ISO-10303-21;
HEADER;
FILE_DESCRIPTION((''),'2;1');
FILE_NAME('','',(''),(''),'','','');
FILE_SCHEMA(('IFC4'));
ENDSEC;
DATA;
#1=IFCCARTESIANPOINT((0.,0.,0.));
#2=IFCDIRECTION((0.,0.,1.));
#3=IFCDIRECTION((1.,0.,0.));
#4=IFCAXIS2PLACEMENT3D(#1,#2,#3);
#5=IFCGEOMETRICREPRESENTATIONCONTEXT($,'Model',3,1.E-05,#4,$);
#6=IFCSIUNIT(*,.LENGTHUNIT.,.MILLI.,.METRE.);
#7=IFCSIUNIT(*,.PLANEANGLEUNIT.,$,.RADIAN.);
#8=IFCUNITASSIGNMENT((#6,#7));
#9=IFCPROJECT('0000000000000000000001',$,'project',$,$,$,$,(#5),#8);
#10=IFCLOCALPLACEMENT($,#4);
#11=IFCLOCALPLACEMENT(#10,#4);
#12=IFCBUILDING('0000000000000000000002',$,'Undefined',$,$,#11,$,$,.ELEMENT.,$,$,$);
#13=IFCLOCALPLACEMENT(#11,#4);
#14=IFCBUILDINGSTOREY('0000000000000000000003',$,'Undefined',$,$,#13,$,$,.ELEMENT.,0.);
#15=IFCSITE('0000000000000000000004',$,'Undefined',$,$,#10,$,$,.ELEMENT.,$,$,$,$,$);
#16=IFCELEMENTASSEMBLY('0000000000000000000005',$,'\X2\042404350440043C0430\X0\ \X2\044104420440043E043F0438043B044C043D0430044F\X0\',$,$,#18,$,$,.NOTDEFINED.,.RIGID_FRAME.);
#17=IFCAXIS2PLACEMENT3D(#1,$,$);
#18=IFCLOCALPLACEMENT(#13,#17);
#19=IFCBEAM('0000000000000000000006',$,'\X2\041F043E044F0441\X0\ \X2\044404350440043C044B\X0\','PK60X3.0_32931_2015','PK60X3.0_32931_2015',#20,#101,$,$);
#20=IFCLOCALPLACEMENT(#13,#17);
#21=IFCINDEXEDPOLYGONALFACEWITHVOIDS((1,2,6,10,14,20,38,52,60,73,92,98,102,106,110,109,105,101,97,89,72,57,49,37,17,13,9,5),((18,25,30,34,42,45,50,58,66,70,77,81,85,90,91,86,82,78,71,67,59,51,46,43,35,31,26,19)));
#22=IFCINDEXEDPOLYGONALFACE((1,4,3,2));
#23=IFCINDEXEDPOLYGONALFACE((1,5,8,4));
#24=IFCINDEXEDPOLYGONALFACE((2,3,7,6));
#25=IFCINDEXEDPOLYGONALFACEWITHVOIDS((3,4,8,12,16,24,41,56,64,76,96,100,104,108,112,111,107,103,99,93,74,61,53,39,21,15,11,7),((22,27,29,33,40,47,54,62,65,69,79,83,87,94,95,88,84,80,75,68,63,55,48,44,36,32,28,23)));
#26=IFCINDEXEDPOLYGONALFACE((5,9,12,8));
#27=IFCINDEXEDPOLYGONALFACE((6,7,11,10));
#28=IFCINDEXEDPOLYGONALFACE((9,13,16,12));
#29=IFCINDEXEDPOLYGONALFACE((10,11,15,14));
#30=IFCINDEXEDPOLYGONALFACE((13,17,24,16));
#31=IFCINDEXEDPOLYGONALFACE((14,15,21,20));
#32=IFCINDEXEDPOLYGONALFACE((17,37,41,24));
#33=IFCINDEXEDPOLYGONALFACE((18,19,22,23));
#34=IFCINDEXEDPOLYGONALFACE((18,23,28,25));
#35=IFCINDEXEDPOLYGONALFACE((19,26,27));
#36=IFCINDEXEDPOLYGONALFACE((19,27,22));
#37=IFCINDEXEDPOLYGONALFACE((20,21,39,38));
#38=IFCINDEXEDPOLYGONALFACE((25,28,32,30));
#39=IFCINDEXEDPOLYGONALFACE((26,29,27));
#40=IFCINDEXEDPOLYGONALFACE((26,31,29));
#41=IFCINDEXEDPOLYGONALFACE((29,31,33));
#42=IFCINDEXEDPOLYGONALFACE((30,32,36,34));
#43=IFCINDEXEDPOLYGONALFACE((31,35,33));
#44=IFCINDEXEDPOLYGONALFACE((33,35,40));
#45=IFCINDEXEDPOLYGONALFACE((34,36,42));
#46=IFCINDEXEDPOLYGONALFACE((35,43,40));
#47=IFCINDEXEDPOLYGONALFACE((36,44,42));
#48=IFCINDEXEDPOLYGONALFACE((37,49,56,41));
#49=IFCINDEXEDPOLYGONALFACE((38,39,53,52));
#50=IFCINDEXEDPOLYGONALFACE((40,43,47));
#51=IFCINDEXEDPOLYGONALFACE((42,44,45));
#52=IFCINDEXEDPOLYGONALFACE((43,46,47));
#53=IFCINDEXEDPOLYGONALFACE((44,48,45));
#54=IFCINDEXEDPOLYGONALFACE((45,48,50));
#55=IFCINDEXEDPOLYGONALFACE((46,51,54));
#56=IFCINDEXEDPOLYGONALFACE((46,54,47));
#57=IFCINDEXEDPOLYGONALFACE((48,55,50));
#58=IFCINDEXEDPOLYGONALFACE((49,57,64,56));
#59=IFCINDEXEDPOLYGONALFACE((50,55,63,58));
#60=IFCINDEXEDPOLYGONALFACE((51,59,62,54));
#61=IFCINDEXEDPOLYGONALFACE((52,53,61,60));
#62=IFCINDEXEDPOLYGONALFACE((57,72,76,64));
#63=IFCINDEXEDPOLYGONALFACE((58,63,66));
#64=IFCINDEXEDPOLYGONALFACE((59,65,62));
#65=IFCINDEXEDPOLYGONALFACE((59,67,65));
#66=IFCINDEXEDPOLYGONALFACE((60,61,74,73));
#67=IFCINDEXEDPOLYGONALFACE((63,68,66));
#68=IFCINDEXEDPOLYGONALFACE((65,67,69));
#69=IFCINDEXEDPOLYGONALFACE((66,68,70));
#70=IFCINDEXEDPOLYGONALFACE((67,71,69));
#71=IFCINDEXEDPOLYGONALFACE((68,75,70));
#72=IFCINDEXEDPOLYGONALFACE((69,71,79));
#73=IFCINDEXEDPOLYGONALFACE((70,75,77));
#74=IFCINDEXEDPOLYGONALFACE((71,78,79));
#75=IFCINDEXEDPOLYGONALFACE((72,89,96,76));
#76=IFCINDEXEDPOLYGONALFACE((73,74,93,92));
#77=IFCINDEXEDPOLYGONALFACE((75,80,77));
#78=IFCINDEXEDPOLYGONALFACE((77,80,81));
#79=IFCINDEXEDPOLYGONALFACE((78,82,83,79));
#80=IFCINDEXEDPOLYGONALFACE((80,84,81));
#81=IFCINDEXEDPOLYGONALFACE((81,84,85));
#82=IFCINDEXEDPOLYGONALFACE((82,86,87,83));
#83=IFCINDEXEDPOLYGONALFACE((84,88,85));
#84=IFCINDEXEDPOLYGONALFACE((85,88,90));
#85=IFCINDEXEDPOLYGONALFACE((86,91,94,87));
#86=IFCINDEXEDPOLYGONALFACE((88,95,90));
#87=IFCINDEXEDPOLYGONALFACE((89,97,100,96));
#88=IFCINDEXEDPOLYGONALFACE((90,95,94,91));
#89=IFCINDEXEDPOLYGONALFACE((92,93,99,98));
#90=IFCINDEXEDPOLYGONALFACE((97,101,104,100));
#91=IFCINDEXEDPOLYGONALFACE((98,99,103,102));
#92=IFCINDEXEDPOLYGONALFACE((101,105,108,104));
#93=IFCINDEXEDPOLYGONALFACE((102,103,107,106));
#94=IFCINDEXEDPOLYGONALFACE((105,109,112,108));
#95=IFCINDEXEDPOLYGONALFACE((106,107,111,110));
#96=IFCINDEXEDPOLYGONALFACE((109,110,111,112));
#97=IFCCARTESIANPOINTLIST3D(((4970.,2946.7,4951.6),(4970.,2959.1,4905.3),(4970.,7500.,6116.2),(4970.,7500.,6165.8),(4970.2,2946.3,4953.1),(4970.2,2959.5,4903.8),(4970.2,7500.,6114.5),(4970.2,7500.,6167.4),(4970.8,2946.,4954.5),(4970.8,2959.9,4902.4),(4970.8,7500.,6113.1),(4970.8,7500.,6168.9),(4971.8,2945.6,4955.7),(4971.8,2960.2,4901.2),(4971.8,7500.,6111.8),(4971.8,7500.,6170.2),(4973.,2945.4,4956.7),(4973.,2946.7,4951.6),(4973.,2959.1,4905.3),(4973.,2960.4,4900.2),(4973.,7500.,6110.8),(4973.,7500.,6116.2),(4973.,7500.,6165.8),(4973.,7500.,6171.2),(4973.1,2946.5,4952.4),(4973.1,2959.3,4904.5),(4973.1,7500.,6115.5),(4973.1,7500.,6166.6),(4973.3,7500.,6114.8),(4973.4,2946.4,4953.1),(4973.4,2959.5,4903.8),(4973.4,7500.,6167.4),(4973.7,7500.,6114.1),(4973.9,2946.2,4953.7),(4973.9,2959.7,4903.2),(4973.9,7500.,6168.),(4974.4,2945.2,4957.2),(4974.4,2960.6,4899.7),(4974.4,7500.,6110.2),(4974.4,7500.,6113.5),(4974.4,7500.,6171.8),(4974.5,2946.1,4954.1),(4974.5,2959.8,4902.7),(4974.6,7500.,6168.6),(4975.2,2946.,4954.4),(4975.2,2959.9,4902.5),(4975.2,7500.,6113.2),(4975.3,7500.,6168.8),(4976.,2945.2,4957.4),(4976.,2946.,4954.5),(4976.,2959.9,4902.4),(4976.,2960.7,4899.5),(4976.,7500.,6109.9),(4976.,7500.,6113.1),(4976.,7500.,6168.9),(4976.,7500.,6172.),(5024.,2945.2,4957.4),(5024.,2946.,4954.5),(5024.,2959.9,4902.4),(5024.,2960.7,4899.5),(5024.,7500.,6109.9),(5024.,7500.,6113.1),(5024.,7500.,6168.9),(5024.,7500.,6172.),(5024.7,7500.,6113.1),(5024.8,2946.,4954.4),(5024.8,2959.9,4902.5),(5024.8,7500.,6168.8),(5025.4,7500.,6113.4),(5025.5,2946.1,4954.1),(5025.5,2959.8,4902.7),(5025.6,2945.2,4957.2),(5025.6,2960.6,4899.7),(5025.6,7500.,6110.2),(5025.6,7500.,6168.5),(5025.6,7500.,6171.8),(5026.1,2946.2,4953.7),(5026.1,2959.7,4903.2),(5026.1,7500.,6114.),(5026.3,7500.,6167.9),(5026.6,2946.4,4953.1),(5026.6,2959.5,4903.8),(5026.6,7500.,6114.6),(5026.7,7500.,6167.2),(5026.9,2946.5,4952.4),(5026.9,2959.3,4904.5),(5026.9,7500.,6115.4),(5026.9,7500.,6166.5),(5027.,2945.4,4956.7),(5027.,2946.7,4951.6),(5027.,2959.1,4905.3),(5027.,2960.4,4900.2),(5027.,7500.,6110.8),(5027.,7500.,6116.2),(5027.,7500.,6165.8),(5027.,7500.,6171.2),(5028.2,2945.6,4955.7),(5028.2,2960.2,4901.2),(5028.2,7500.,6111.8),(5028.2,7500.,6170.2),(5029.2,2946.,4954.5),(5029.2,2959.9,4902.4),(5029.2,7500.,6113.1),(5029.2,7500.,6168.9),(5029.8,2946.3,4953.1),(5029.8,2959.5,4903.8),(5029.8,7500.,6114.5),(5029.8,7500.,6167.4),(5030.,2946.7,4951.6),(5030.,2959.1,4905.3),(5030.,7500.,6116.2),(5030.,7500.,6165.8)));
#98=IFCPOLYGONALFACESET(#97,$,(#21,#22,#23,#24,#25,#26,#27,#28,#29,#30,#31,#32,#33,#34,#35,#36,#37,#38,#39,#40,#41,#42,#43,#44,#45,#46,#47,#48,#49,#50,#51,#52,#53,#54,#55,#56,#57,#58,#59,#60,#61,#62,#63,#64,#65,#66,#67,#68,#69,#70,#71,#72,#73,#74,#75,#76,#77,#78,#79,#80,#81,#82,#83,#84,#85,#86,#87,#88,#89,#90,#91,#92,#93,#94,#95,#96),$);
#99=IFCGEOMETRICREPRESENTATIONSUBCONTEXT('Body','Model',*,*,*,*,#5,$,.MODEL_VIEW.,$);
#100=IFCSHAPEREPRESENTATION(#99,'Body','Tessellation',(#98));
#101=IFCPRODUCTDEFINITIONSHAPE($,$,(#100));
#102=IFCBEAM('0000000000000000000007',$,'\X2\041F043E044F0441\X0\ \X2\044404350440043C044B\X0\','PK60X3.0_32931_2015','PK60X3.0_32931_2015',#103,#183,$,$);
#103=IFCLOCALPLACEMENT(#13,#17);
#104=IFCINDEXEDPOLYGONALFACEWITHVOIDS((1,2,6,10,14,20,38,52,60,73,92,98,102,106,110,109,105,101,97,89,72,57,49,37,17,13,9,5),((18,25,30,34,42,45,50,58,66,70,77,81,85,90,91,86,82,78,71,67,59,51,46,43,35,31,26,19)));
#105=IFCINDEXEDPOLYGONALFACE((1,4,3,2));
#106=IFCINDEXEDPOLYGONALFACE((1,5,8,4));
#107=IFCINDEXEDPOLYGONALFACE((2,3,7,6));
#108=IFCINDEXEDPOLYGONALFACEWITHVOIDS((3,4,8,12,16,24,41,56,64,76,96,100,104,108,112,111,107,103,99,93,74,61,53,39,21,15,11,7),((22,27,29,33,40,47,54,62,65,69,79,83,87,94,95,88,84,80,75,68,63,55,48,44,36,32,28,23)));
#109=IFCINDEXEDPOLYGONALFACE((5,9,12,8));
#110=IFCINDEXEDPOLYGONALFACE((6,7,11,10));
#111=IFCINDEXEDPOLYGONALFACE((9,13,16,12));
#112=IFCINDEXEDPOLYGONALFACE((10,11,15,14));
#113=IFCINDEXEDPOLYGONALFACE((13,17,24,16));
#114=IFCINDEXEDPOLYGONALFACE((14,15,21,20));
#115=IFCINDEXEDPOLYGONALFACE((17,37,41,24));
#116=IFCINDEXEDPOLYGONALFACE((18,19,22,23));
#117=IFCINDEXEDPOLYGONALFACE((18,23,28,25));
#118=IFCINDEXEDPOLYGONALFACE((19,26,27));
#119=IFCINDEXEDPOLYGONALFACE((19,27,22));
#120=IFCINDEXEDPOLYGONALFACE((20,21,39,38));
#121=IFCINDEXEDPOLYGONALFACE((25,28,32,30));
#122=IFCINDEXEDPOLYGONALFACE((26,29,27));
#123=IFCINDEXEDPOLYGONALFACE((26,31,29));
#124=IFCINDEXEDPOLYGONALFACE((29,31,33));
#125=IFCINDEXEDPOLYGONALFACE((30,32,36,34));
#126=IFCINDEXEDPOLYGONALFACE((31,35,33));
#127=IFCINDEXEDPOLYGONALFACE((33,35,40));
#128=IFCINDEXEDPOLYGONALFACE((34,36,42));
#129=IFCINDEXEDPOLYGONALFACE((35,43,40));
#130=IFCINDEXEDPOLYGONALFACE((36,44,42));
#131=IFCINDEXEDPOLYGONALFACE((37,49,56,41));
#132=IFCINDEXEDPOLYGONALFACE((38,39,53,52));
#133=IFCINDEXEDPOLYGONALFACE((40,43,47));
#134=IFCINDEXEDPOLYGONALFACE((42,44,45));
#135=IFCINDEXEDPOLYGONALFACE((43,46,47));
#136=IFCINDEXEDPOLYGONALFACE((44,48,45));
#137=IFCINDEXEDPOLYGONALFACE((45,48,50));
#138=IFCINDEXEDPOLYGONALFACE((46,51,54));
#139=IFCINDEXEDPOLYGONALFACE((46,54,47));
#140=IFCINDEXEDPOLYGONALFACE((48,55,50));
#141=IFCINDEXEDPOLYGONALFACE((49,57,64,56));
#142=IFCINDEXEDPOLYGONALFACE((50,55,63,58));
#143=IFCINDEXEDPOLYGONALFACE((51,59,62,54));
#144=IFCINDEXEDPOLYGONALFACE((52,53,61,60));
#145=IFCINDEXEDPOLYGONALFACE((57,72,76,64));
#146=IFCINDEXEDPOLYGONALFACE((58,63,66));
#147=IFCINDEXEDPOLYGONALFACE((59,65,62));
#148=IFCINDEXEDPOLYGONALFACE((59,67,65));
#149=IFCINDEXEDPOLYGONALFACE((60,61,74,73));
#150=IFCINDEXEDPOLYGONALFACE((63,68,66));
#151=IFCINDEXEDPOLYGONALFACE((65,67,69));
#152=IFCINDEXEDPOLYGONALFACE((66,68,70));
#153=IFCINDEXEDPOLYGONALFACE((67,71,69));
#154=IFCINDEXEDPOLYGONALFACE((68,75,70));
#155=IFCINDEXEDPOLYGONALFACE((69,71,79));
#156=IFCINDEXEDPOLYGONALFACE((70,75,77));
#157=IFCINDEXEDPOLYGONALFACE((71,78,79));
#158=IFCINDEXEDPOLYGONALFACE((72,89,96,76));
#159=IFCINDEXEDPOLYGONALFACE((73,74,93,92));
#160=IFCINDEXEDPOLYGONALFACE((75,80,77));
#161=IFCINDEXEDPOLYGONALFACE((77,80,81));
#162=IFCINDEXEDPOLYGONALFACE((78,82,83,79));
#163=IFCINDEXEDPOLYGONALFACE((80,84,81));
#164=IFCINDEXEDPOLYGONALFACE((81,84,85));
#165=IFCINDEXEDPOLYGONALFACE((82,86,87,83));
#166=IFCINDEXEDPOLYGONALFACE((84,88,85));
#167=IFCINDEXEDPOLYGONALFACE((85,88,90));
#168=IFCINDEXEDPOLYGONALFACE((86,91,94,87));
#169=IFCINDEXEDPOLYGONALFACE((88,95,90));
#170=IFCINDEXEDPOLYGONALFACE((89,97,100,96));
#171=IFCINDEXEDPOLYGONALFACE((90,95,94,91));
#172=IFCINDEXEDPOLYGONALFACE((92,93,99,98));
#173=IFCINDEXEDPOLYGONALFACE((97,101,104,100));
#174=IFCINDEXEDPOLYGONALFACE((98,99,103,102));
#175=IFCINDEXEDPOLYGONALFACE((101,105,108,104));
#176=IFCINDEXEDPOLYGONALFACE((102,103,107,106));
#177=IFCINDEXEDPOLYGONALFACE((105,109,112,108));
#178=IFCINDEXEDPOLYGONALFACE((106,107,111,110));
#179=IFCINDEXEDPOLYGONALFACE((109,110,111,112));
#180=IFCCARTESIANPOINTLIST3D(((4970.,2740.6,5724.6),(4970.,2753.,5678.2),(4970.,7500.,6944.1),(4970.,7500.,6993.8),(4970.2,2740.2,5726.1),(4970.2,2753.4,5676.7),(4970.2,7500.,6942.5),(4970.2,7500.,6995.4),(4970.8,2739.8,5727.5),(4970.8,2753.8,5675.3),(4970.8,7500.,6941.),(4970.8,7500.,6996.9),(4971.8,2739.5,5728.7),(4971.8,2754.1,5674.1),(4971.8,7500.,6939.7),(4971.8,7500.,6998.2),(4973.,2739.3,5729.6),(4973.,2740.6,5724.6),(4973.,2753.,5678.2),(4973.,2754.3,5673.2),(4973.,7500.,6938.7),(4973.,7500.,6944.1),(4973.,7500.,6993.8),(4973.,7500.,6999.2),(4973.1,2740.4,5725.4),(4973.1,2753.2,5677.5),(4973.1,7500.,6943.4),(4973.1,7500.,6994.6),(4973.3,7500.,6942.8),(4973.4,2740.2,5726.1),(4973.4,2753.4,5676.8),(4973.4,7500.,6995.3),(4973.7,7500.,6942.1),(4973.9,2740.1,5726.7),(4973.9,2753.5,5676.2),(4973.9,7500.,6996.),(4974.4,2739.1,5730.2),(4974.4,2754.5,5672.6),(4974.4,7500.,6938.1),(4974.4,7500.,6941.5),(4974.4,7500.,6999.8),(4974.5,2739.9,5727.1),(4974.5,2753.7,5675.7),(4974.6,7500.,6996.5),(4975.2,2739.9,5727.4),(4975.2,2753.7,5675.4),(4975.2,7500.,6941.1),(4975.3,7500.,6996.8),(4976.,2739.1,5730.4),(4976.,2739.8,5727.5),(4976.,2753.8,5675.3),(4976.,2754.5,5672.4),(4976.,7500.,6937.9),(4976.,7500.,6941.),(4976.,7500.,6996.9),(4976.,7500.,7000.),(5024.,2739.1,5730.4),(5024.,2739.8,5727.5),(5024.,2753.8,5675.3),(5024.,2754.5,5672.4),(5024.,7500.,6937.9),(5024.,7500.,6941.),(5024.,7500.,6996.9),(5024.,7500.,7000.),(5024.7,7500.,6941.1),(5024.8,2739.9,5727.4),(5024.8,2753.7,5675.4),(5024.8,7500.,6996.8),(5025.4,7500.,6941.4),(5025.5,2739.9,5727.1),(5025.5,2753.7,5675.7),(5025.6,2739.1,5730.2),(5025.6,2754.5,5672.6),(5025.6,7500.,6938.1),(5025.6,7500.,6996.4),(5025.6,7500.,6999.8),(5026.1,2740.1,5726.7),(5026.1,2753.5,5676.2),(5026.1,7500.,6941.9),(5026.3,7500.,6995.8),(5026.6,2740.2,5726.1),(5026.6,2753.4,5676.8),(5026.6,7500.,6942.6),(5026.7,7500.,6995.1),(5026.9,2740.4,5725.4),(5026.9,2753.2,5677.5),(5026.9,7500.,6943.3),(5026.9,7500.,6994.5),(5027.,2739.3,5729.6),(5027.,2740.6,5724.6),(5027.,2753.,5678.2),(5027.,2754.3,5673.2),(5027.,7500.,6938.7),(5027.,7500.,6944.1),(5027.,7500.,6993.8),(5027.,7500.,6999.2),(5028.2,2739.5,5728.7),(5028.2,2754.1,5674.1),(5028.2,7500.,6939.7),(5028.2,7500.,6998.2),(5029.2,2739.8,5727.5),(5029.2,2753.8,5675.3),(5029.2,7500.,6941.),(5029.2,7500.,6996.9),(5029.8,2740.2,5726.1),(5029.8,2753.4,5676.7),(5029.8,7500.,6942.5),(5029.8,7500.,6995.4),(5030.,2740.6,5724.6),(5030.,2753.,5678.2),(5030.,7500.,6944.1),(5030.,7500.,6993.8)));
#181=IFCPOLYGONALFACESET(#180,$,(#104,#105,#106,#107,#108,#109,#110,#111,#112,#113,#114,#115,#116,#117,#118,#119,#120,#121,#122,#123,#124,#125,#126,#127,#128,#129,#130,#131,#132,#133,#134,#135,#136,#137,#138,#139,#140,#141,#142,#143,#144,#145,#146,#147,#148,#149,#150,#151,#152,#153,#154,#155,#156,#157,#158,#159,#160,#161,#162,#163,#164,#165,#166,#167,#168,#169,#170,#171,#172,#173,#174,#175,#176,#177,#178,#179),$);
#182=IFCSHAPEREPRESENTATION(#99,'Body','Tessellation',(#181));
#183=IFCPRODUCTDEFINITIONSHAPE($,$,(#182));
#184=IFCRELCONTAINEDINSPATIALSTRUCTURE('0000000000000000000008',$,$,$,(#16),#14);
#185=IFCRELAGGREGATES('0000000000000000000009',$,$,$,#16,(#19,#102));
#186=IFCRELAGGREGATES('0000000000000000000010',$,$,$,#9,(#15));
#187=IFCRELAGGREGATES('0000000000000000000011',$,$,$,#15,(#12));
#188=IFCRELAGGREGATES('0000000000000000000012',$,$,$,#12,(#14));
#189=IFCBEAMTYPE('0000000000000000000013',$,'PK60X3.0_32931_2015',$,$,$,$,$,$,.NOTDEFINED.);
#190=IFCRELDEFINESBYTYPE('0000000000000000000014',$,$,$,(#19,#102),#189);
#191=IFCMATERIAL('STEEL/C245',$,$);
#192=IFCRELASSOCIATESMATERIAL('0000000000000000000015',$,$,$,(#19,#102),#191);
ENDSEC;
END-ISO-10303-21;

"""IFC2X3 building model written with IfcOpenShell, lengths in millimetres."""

from ifc_helpers import new_model, si_unit, frame, origin_with_axes, origin_2d_with_axis, place, context, subcontext, project, spatial, hollow_rectangle, extrude, clip, halfspace, material, type_object, element, aggregate, save


model = new_model("IFC2X3")

# Units and contexts
model_context = context("Model", 3, precision=1e-05, world=origin_with_axes())
body_context = subcontext(model_context, "Body", "Model", "MODEL_VIEW")
ifc_project = project(units=[si_unit("LENGTHUNIT", "METRE", prefix="MILLI"), si_unit("PLANEANGLEUNIT", "RADIAN")], contexts=[model_context])

# Site, building, storey
site_placement = place(None, origin_with_axes())
site = spatial("IfcSite", under=ifc_project, at=site_placement, Name="Undefined", CompositionType="ELEMENT")
building_placement = place(site_placement, origin_with_axes())
building = spatial("IfcBuilding", under=site, at=building_placement, Name="Undefined", CompositionType="ELEMENT")
storey_placement = place(building_placement, origin_with_axes())
storey = spatial("IfcBuildingStorey", under=building, at=storey_placement, Name="Undefined", CompositionType="ELEMENT", Elevation=0.0)

# Shared definitions
ifc_material_1 = material(Name="STEEL/C245")

# Element assembly, beams
assembly_1_placement = place(storey_placement, origin_with_axes())
assembly_1 = element("IfcElementAssembly", 1, at=assembly_1_placement, inside=storey, Name="Ферма стропильная", AssemblyPlace="NOTDEFINED", PredefinedType="RIGID_FRAME")
beam_type_1 = type_object("IfcBeamType", Name="PK60X3.0_32931_2015", PredefinedType="NOTDEFINED")
beam_1_placement = place(assembly_1_placement, frame((5000.0, 2952.9, 4928.4), z_axis=(0.0, -0.257663, 0.966235), x_axis=(0.0, 0.966235, 0.257663)))
beam_1 = element("IfcBeam", 2, at=beam_1_placement, type_object=beam_type_1, material=ifc_material_1, Name="Пояс фермы", Description="PK60X3.0_32931_2015", ObjectType="PK60X3.0_32931_2015", context=body_context, shape_type="Clipping", body=[
    clip(extrude(hollow_rectangle(XDim=60.0, YDim=60.0, WallThickness=3.0, InnerFilletRadius=3.0, OuterFilletRadius=6.0, at=origin_2d_with_axis()), frame((4729.1, 0.0, 0.0), z_axis=(-1.0, 0.0, 0.0), x_axis=(0.0, -1.0, 0.0)), (0.0, 0.0, 1.0), 4729.1), halfspace(frame((4938.1, 0.0, 870.5), z_axis=(0.966235, 0.0, -0.257663), x_axis=(0.0, -1.0, 0.0)), False)),
])
beam_2_placement = place(assembly_1_placement, frame((5000.0, 2746.8, 5701.4), z_axis=(0.0, -0.257663, 0.966235), x_axis=(0.0, 0.966235, 0.257663)))
beam_2 = element("IfcBeam", 3, at=beam_2_placement, type_object=beam_type_1, material=ifc_material_1, Name="Пояс фермы", Description="PK60X3.0_32931_2015", ObjectType="PK60X3.0_32931_2015", context=body_context, shape_type="Clipping", body=[
    clip(extrude(hollow_rectangle(XDim=60.0, YDim=60.0, WallThickness=3.0, InnerFilletRadius=3.0, OuterFilletRadius=6.0, at=origin_2d_with_axis()), frame((4942.5, 0.0, 0.0), z_axis=(-1.0, 0.0, 0.0), x_axis=(0.0, -1.0, 0.0)), (0.0, 0.0, 1.0), 4942.5), halfspace(frame((4938.1, 0.0, 70.5), z_axis=(0.966235, 0.0, -0.257663), x_axis=(0.0, -1.0, 0.0)), False)),
])

aggregate(assembly_1, [beam_1, beam_2])

save(model, "model.ifc")
